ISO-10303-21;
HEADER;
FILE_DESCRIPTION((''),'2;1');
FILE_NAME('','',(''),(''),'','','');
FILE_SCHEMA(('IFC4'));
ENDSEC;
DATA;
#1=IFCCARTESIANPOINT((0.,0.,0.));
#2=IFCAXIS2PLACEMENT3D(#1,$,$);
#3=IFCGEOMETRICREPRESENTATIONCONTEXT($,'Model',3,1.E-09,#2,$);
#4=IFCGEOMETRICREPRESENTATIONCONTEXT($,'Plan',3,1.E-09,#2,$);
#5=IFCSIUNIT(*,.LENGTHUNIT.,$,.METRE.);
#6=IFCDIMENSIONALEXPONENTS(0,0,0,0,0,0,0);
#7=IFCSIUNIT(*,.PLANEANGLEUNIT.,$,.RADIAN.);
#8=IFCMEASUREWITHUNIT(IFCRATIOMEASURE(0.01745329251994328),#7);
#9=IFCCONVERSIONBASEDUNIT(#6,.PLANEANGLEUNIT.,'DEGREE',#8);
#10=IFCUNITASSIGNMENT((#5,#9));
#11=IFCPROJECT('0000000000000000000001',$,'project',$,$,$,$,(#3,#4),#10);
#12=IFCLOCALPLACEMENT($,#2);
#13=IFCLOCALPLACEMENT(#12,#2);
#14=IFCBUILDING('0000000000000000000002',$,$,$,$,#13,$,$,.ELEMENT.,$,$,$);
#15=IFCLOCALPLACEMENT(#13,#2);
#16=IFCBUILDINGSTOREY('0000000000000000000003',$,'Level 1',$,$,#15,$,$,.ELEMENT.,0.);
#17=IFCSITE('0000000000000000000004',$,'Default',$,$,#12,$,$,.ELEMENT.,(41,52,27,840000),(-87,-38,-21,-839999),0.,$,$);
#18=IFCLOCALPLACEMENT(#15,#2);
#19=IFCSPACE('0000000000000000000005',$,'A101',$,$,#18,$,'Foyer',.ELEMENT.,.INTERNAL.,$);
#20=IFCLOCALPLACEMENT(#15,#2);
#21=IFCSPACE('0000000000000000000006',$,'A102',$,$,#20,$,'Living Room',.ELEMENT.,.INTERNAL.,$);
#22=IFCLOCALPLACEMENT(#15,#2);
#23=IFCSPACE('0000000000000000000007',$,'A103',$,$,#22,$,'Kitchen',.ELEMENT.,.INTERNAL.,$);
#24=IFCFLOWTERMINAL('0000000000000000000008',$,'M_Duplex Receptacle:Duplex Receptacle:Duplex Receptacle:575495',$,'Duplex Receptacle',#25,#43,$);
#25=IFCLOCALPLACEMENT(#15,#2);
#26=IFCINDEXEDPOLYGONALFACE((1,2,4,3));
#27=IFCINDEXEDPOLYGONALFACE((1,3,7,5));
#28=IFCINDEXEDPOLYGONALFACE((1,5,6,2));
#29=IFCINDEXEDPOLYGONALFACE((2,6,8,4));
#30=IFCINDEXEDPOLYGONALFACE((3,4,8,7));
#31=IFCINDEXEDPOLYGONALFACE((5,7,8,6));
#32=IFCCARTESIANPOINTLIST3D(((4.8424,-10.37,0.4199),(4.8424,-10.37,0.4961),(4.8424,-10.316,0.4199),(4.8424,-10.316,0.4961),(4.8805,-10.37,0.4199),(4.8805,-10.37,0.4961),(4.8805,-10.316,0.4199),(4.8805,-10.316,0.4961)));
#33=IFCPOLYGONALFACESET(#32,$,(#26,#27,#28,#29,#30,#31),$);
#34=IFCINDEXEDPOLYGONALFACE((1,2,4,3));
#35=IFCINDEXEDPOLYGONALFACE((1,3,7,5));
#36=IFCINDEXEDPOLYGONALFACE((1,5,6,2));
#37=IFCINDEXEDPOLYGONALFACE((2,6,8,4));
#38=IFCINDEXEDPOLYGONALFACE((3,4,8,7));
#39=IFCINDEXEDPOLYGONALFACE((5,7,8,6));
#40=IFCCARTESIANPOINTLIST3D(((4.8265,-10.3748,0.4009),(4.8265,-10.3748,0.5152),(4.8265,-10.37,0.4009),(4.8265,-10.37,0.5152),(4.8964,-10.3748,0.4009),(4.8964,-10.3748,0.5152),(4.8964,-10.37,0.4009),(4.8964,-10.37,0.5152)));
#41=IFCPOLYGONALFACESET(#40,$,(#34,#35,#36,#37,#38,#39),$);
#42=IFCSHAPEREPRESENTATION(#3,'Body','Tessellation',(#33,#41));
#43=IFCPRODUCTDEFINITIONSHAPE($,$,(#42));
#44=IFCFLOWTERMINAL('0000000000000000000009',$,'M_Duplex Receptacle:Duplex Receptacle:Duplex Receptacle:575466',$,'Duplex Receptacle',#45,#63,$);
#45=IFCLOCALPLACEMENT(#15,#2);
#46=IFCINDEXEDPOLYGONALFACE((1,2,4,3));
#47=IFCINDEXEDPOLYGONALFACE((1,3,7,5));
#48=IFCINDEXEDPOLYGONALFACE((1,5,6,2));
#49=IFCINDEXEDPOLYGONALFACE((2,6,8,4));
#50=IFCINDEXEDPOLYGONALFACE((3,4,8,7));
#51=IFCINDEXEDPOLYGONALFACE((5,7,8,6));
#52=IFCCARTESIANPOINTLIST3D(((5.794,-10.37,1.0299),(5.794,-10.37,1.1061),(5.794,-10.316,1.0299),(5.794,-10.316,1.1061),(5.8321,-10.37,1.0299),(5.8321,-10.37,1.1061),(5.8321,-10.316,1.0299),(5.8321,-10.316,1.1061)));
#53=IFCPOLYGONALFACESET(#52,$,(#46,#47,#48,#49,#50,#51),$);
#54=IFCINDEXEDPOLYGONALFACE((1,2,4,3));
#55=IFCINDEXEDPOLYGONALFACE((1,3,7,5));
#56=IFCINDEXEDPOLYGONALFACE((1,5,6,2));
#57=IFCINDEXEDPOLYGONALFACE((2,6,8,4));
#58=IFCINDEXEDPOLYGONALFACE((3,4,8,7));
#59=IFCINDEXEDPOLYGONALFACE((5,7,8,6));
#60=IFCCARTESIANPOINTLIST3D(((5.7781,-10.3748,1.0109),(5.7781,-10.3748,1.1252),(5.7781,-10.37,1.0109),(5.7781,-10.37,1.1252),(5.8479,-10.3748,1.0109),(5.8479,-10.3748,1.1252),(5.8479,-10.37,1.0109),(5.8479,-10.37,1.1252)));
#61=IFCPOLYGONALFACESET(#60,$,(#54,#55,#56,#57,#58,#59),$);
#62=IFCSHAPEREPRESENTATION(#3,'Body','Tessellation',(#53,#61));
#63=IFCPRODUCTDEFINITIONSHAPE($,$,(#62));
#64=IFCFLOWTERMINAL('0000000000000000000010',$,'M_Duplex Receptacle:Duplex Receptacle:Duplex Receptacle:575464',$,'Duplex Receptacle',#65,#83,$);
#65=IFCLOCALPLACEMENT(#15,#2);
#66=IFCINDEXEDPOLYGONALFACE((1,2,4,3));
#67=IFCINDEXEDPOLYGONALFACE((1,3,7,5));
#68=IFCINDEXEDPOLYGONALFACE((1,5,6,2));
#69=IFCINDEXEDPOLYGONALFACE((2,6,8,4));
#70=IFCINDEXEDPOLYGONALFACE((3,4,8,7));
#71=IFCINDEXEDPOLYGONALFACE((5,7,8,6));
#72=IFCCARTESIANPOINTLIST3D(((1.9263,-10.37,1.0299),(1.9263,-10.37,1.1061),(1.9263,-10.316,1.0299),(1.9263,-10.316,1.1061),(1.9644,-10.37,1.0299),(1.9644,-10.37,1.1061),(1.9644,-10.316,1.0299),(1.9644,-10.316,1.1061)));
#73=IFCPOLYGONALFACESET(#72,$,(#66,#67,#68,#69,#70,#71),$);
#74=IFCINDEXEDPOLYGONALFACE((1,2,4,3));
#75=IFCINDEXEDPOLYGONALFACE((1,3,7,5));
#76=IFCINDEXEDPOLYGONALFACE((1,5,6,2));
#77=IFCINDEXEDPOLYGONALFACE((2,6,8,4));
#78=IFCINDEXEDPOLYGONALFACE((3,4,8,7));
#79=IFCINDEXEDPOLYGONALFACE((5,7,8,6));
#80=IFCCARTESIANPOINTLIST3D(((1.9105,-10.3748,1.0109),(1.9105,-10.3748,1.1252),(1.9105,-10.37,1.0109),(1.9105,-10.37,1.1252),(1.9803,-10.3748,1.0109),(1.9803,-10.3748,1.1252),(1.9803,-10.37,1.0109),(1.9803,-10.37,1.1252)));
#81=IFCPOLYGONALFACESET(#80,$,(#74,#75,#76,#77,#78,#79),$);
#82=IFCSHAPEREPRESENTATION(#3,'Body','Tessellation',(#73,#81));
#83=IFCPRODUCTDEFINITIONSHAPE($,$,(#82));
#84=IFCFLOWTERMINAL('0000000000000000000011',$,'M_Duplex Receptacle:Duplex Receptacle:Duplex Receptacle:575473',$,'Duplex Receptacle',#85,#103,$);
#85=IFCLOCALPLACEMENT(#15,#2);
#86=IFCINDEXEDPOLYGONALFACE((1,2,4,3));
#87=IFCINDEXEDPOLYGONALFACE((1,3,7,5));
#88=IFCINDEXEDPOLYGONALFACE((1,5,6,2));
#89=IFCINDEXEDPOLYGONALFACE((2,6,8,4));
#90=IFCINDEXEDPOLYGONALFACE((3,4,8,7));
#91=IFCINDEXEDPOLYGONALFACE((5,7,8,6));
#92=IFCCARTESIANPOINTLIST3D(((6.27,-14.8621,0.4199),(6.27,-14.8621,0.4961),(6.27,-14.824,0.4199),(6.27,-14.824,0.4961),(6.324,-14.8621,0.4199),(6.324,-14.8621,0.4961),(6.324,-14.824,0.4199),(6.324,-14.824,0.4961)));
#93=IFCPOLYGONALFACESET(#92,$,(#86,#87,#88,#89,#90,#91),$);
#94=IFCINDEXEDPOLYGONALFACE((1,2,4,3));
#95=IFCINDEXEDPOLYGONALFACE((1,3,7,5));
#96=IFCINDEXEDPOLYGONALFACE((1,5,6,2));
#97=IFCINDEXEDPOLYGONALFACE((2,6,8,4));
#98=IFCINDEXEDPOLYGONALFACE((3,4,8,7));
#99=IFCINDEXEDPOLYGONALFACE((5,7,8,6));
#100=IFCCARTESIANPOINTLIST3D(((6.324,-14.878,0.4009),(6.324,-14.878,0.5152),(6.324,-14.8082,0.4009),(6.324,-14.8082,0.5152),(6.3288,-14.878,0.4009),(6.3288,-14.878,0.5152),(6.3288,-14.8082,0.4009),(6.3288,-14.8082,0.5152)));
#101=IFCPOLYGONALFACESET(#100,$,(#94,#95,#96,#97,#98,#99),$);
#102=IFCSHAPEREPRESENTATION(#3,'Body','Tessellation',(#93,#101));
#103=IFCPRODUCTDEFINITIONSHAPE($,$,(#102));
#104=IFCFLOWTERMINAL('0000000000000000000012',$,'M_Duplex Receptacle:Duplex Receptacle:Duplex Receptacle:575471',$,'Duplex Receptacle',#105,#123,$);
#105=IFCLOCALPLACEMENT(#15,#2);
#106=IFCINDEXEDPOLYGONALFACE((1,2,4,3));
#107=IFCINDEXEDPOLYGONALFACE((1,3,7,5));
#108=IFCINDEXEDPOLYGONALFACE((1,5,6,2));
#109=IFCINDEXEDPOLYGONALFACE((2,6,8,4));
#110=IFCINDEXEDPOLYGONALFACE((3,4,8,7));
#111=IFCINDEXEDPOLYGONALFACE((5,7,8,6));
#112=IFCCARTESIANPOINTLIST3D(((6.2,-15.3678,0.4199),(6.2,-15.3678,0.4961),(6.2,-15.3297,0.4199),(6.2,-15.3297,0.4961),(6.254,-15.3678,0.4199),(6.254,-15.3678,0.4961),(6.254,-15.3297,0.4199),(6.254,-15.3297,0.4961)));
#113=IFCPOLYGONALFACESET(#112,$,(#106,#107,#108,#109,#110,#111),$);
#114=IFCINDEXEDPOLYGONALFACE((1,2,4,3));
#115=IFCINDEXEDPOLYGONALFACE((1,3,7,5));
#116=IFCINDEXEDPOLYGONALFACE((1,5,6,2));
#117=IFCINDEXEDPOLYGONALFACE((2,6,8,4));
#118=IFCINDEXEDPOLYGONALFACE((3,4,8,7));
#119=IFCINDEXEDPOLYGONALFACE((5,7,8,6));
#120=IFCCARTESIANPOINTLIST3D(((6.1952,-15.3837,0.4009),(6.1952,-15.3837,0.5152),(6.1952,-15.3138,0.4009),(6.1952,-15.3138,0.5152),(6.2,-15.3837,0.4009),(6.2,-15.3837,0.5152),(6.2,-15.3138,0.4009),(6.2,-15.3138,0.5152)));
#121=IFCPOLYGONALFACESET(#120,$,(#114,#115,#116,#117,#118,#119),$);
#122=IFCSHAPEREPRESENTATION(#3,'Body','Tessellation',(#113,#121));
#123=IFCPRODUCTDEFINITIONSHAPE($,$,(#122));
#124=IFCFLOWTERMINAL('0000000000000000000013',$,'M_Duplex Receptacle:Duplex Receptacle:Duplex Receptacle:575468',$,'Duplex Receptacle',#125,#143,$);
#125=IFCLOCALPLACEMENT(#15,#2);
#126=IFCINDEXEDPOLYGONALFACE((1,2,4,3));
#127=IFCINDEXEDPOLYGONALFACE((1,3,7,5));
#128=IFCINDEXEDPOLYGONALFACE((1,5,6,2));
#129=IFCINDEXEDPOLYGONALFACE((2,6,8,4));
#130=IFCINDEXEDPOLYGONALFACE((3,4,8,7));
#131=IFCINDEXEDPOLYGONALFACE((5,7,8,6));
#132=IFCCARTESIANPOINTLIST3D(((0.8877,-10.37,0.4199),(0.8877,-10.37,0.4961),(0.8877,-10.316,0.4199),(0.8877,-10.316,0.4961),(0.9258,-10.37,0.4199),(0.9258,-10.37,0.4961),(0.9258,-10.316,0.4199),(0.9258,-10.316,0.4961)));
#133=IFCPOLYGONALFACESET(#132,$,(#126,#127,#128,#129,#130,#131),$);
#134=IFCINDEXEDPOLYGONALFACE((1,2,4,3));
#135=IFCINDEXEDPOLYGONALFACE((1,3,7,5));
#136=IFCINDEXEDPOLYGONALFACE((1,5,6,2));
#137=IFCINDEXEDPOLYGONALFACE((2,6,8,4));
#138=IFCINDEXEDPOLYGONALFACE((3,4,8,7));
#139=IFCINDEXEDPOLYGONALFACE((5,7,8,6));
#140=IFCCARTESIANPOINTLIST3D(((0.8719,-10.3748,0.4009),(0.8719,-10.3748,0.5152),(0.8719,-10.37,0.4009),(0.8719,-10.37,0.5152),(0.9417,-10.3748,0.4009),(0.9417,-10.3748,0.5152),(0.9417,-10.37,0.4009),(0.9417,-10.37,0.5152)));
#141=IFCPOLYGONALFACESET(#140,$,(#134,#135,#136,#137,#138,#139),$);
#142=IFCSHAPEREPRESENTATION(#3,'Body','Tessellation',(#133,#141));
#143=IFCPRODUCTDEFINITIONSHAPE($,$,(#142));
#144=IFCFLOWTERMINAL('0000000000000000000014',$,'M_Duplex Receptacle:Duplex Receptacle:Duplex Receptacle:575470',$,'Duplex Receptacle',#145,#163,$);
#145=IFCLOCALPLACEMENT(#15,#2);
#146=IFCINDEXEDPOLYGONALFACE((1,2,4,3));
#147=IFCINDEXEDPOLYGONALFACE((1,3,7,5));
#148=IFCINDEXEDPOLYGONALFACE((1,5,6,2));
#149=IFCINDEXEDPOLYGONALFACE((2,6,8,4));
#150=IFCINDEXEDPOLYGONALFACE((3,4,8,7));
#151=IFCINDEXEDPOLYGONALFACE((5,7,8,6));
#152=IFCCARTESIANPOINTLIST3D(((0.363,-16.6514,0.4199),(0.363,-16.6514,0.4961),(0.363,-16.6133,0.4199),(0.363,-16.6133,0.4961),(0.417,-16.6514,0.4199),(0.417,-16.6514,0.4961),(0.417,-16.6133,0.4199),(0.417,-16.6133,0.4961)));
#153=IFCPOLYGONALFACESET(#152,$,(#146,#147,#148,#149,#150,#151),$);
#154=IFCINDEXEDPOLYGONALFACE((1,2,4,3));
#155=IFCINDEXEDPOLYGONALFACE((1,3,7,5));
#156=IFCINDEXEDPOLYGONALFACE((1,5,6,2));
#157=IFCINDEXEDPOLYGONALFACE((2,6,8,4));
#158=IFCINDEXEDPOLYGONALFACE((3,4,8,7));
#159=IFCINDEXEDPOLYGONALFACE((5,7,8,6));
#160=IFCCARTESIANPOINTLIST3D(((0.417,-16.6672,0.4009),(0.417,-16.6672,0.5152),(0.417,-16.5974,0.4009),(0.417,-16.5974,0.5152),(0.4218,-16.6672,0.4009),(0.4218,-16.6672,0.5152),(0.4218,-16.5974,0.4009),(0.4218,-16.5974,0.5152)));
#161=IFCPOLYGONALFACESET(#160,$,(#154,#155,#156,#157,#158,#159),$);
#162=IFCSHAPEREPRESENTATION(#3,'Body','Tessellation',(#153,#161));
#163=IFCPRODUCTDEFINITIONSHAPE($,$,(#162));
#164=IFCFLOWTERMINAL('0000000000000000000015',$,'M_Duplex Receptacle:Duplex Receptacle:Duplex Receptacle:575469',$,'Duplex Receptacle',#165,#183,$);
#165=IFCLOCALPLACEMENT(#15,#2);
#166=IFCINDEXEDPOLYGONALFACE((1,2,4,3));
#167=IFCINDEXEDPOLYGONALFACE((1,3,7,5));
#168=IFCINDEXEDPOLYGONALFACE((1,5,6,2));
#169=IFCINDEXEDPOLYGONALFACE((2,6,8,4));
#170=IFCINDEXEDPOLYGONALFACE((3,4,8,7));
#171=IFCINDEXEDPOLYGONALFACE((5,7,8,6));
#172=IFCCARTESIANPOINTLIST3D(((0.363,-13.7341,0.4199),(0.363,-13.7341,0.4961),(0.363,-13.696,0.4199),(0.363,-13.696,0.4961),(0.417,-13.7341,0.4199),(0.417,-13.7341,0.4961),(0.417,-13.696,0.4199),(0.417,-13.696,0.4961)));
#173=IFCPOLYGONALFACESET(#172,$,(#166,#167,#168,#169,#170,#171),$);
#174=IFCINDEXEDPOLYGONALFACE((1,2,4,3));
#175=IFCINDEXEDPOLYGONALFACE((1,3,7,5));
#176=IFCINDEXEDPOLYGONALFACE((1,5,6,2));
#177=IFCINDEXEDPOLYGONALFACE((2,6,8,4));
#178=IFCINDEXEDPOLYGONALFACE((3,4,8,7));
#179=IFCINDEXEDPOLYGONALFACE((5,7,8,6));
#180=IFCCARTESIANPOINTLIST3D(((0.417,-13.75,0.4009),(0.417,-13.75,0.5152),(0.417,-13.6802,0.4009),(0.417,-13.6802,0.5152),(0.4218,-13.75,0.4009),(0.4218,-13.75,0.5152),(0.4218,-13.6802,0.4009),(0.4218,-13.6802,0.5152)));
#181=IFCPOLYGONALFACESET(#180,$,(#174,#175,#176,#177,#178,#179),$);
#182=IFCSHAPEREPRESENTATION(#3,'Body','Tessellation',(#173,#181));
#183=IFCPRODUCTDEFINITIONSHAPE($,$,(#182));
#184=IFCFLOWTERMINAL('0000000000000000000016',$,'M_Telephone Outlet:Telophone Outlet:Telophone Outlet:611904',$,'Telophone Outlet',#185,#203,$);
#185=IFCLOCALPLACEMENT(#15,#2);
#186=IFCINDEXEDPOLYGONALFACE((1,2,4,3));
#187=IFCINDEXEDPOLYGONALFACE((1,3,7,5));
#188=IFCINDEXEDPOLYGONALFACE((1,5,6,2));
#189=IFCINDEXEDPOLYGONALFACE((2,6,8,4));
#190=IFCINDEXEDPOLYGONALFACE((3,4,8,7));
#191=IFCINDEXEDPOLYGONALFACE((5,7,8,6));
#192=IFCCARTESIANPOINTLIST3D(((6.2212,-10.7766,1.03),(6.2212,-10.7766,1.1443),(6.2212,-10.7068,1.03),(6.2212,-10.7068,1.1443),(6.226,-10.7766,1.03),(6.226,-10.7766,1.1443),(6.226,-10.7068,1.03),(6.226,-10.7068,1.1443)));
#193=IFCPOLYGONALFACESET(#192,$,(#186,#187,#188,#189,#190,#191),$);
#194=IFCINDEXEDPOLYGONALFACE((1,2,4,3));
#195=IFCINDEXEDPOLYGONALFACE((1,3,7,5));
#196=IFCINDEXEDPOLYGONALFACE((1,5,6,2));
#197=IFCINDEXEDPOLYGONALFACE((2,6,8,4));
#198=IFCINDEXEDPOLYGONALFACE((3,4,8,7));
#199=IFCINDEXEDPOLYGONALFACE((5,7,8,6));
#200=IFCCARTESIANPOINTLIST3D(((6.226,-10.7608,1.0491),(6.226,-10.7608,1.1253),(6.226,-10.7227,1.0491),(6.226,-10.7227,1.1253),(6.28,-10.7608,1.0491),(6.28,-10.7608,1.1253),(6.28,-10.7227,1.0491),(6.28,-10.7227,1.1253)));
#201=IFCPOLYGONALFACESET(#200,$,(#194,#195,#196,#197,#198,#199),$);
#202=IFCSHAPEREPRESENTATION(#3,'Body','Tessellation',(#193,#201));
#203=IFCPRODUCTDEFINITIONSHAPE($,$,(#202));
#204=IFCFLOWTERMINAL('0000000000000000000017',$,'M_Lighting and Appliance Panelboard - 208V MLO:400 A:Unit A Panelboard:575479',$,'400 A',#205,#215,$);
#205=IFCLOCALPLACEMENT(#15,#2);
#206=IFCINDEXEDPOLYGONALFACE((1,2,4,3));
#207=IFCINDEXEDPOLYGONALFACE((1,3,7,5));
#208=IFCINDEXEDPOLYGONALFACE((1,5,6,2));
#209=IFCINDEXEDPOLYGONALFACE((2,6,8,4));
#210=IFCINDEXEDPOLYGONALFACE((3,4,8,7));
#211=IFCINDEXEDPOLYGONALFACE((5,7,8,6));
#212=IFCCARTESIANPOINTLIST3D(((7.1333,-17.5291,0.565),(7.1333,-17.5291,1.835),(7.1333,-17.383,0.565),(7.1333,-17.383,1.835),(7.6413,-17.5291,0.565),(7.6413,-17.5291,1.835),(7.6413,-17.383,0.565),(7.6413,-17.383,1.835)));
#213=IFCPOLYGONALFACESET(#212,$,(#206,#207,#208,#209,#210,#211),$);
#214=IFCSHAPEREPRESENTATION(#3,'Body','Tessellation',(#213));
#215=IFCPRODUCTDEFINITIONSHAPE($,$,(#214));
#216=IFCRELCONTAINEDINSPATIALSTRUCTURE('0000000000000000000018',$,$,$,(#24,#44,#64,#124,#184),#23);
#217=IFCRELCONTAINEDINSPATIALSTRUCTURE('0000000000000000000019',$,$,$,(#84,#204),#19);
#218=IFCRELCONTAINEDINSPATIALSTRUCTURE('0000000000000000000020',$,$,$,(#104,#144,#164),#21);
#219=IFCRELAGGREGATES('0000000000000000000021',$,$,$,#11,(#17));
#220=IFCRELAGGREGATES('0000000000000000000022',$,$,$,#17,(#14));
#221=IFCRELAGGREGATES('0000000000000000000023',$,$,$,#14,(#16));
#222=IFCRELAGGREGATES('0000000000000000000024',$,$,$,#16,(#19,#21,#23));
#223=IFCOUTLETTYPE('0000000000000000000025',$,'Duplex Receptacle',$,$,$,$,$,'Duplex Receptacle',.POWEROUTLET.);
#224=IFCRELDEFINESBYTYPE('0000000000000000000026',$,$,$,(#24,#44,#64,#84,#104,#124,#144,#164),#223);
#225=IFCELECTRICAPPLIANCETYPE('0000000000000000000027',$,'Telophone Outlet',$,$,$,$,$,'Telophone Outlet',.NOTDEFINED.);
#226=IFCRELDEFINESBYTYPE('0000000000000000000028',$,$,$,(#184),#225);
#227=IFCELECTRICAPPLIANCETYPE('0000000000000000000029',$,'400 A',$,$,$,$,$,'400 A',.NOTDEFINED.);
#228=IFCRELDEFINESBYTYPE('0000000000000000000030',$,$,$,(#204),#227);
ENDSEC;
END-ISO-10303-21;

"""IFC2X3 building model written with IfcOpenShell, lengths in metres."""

from ifc_helpers import new_model, entity, si_unit, converted_unit, frame, origin, origin_2d_with_axis, place, context, project, spatial, rectangle, extrude, source, transform, mapped, type_object, type_shapes, element, save


model = new_model("IFC2X3")

# Units and contexts
model_context = context("Model", 3, precision=1e-09, world=origin())
plan_context = context("Plan", 3, precision=1e-09, world=origin())
ifc_project = project(units=[si_unit("LENGTHUNIT", "METRE"), converted_unit("PLANEANGLEUNIT", "DEGREE", entity("IfcRatioMeasure", 0.01745329251994328), si_unit("PLANEANGLEUNIT", "RADIAN"), dimensions=[0, 0, 0, 0, 0, 0, 0])], contexts=[model_context, plan_context])

# Site, building, storey, space
site_placement = place(None, origin())
site = spatial("IfcSite", under=ifc_project, at=site_placement, Name="Default", CompositionType="ELEMENT", RefLatitude=(41, 52, 27, 840000), RefLongitude=(-87, -38, -21, -839999), RefElevation=0.0)
building_placement = place(site_placement, origin())
building = spatial("IfcBuilding", under=site, at=building_placement, CompositionType="ELEMENT")
storey_placement = place(building_placement, origin())
storey = spatial("IfcBuildingStorey", under=building, at=storey_placement, Name="Level 1", CompositionType="ELEMENT", Elevation=0.0)
space_1_placement = place(storey_placement, origin())
space_1 = spatial("IfcSpace", under=storey, at=space_1_placement, Name="A101", LongName="Foyer", CompositionType="ELEMENT", InteriorOrExteriorSpace="INTERNAL")

# Shared definitions
shared_shape_1 = source(origin(), model_context, "Body", "SweptSolid", [
    extrude(rectangle(XDim=0.0381, YDim=0.0762, at=origin_2d_with_axis()), frame((0.0, 0.0, -0.054), z_axis=(0.0, 0.0, 1.0), x_axis=(-1.0, 0.0, 0.0)), (0.0, 0.0, 1.0), 0.054),
    extrude(rectangle(XDim=0.0698, YDim=0.1143, at=origin_2d_with_axis()), frame((0.0, 0.0, 0.0), z_axis=(0.0, 0.0, 1.0), x_axis=(-1.0, 0.0, 0.0)), (0.0, 0.0, 1.0), 0.0048),
])

# Shared definitions
space_2_placement = place(storey_placement, origin())
space_2 = spatial("IfcSpace", under=storey, at=space_2_placement, Name="A102", LongName="Living Room", CompositionType="ELEMENT", InteriorOrExteriorSpace="INTERNAL")

# Shared definitions
space_3_placement = place(storey_placement, origin())
space_3 = spatial("IfcSpace", under=storey, at=space_3_placement, Name="A103", LongName="Kitchen", CompositionType="ELEMENT", InteriorOrExteriorSpace="INTERNAL")

# Shared definitions
outlet_type = type_object("IfcOutletType", Name="Duplex Receptacle", ElementType="Duplex Receptacle", PredefinedType="POWEROUTLET")
type_shapes(outlet_type, [shared_shape_1])

# Flow terminals
for number, where, z_axis, x_axis, name in (
    (1, (4.8615, -10.37, 0.458), (0.0, -1.0, 0.0), (1.0, 0.0, 0.0), "M_Duplex Receptacle:Duplex Receptacle:Duplex Receptacle:575495"),
    (2, (5.813, -10.37, 1.068), (0.0, -1.0, 0.0), (1.0, 0.0, 0.0), "M_Duplex Receptacle:Duplex Receptacle:Duplex Receptacle:575466"),
    (3, (1.9454, -10.37, 1.068), (0.0, -1.0, 0.0), (1.0, 0.0, 0.0), "M_Duplex Receptacle:Duplex Receptacle:Duplex Receptacle:575464"),
):
    element("IfcFlowTerminal", number, at=place(space_3_placement, frame(where, z_axis=z_axis, x_axis=x_axis)), inside=space_3, type_object=outlet_type, Name=name, ObjectType="Duplex Receptacle", context=model_context, shape_type="MappedRepresentation", body=[
        mapped(shared_shape_1, transform((0.0, 0.0, 0.0), scale=1.0)),
    ])
flow_terminal_1_placement = place(space_1_placement, frame((6.324, -14.8431, 0.458), z_axis=(1.0, 0.0, 0.0), x_axis=(0.0, 1.0, 0.0)))
element("IfcFlowTerminal", 4, at=flow_terminal_1_placement, inside=space_1, type_object=outlet_type, Name="M_Duplex Receptacle:Duplex Receptacle:Duplex Receptacle:575473", ObjectType="Duplex Receptacle", context=model_context, shape_type="MappedRepresentation", body=[
    mapped(shared_shape_1, transform((0.0, 0.0, 0.0), scale=1.0)),
])
flow_terminal_2_placement = place(space_2_placement, frame((6.2, -15.3487, 0.458), z_axis=(-1.0, 0.0, 0.0), x_axis=(0.0, -1.0, 0.0)))
element("IfcFlowTerminal", 5, at=flow_terminal_2_placement, inside=space_2, type_object=outlet_type, Name="M_Duplex Receptacle:Duplex Receptacle:Duplex Receptacle:575471", ObjectType="Duplex Receptacle", context=model_context, shape_type="MappedRepresentation", body=[
    mapped(shared_shape_1, transform((0.0, 0.0, 0.0), scale=1.0)),
])
flow_terminal_3_placement = place(space_3_placement, frame((0.9068, -10.37, 0.458), z_axis=(0.0, -1.0, 0.0), x_axis=(1.0, 0.0, 0.0)))
element("IfcFlowTerminal", 6, at=flow_terminal_3_placement, inside=space_3, type_object=outlet_type, Name="M_Duplex Receptacle:Duplex Receptacle:Duplex Receptacle:575468", ObjectType="Duplex Receptacle", context=model_context, shape_type="MappedRepresentation", body=[
    mapped(shared_shape_1, transform((0.0, 0.0, 0.0), scale=1.0)),
])
for number, where, z_axis, x_axis, name in (
    (7, (0.417, -16.6323, 0.458), (1.0, 0.0, 0.0), (0.0, 1.0, 0.0), "M_Duplex Receptacle:Duplex Receptacle:Duplex Receptacle:575470"),
    (8, (0.417, -13.7151, 0.458), (1.0, 0.0, 0.0), (0.0, 1.0, 0.0), "M_Duplex Receptacle:Duplex Receptacle:Duplex Receptacle:575469"),
):
    element("IfcFlowTerminal", number, at=place(space_2_placement, frame(where, z_axis=z_axis, x_axis=x_axis)), inside=space_2, type_object=outlet_type, Name=name, ObjectType="Duplex Receptacle", context=model_context, shape_type="MappedRepresentation", body=[
        mapped(shared_shape_1, transform((0.0, 0.0, 0.0), scale=1.0)),
    ])
electric_appliance_type_1 = type_object("IfcElectricApplianceType", Name="Telophone Outlet", ElementType="Telophone Outlet", PredefinedType="NOTDEFINED")
shared_shape_2 = source(origin(), model_context, "Body", "SweptSolid", [
    extrude(rectangle(XDim=0.0699, YDim=0.1143, at=origin_2d_with_axis()), frame((0.0, 0.0, 0.0), z_axis=(0.0, 0.0, 1.0), x_axis=(-1.0, 0.0, 0.0)), (0.0, 0.0, 1.0), 0.0048),
    extrude(rectangle(XDim=0.0381, YDim=0.0762, at=origin_2d_with_axis()), frame((0.0, 0.0, -0.054), z_axis=(0.0, 0.0, 1.0), x_axis=(-1.0, 0.0, 0.0)), (0.0, 0.0, 1.0), 0.054),
])
type_shapes(electric_appliance_type_1, [shared_shape_2])
flow_terminal_4_placement = place(space_3_placement, frame((6.226, -10.7417, 1.0872), z_axis=(-1.0, 0.0, 0.0), x_axis=(0.0, -1.0, 0.0)))
element("IfcFlowTerminal", 9, at=flow_terminal_4_placement, inside=space_3, type_object=electric_appliance_type_1, Name="M_Telephone Outlet:Telophone Outlet:Telophone Outlet:611904", ObjectType="Telophone Outlet", context=model_context, shape_type="MappedRepresentation", body=[
    mapped(shared_shape_2, transform((0.0, 0.0, 0.0), scale=1.0)),
])
electric_appliance_type_2 = type_object("IfcElectricApplianceType", Name="400 A", ElementType="400 A", PredefinedType="NOTDEFINED")
shared_shape_3 = source(origin(), model_context, "Body", "SweptSolid", [
    extrude(rectangle(XDim=0.508, YDim=1.27, at=origin_2d_with_axis()), frame((0.0, -0.4191, -0.1461), z_axis=(0.0, 0.0, 1.0), x_axis=(-1.0, 0.0, 0.0)), (0.0, 0.0, 1.0), 0.1461),
])
type_shapes(electric_appliance_type_2, [shared_shape_3])
flow_terminal_5_placement = place(space_1_placement, frame((7.3873, -17.383, 1.6191), z_axis=(0.0, 1.0, 0.0), x_axis=(-1.0, 0.0, 0.0)))
element("IfcFlowTerminal", 10, at=flow_terminal_5_placement, inside=space_1, type_object=electric_appliance_type_2, Name="M_Lighting and Appliance Panelboard - 208V MLO:400 A:Unit A Panelboard:575479", ObjectType="400 A", context=model_context, shape_type="MappedRepresentation", body=[
    mapped(shared_shape_3, transform((0.0, 0.0, 0.0), scale=1.0)),
])

save(model, "model.ifc")
